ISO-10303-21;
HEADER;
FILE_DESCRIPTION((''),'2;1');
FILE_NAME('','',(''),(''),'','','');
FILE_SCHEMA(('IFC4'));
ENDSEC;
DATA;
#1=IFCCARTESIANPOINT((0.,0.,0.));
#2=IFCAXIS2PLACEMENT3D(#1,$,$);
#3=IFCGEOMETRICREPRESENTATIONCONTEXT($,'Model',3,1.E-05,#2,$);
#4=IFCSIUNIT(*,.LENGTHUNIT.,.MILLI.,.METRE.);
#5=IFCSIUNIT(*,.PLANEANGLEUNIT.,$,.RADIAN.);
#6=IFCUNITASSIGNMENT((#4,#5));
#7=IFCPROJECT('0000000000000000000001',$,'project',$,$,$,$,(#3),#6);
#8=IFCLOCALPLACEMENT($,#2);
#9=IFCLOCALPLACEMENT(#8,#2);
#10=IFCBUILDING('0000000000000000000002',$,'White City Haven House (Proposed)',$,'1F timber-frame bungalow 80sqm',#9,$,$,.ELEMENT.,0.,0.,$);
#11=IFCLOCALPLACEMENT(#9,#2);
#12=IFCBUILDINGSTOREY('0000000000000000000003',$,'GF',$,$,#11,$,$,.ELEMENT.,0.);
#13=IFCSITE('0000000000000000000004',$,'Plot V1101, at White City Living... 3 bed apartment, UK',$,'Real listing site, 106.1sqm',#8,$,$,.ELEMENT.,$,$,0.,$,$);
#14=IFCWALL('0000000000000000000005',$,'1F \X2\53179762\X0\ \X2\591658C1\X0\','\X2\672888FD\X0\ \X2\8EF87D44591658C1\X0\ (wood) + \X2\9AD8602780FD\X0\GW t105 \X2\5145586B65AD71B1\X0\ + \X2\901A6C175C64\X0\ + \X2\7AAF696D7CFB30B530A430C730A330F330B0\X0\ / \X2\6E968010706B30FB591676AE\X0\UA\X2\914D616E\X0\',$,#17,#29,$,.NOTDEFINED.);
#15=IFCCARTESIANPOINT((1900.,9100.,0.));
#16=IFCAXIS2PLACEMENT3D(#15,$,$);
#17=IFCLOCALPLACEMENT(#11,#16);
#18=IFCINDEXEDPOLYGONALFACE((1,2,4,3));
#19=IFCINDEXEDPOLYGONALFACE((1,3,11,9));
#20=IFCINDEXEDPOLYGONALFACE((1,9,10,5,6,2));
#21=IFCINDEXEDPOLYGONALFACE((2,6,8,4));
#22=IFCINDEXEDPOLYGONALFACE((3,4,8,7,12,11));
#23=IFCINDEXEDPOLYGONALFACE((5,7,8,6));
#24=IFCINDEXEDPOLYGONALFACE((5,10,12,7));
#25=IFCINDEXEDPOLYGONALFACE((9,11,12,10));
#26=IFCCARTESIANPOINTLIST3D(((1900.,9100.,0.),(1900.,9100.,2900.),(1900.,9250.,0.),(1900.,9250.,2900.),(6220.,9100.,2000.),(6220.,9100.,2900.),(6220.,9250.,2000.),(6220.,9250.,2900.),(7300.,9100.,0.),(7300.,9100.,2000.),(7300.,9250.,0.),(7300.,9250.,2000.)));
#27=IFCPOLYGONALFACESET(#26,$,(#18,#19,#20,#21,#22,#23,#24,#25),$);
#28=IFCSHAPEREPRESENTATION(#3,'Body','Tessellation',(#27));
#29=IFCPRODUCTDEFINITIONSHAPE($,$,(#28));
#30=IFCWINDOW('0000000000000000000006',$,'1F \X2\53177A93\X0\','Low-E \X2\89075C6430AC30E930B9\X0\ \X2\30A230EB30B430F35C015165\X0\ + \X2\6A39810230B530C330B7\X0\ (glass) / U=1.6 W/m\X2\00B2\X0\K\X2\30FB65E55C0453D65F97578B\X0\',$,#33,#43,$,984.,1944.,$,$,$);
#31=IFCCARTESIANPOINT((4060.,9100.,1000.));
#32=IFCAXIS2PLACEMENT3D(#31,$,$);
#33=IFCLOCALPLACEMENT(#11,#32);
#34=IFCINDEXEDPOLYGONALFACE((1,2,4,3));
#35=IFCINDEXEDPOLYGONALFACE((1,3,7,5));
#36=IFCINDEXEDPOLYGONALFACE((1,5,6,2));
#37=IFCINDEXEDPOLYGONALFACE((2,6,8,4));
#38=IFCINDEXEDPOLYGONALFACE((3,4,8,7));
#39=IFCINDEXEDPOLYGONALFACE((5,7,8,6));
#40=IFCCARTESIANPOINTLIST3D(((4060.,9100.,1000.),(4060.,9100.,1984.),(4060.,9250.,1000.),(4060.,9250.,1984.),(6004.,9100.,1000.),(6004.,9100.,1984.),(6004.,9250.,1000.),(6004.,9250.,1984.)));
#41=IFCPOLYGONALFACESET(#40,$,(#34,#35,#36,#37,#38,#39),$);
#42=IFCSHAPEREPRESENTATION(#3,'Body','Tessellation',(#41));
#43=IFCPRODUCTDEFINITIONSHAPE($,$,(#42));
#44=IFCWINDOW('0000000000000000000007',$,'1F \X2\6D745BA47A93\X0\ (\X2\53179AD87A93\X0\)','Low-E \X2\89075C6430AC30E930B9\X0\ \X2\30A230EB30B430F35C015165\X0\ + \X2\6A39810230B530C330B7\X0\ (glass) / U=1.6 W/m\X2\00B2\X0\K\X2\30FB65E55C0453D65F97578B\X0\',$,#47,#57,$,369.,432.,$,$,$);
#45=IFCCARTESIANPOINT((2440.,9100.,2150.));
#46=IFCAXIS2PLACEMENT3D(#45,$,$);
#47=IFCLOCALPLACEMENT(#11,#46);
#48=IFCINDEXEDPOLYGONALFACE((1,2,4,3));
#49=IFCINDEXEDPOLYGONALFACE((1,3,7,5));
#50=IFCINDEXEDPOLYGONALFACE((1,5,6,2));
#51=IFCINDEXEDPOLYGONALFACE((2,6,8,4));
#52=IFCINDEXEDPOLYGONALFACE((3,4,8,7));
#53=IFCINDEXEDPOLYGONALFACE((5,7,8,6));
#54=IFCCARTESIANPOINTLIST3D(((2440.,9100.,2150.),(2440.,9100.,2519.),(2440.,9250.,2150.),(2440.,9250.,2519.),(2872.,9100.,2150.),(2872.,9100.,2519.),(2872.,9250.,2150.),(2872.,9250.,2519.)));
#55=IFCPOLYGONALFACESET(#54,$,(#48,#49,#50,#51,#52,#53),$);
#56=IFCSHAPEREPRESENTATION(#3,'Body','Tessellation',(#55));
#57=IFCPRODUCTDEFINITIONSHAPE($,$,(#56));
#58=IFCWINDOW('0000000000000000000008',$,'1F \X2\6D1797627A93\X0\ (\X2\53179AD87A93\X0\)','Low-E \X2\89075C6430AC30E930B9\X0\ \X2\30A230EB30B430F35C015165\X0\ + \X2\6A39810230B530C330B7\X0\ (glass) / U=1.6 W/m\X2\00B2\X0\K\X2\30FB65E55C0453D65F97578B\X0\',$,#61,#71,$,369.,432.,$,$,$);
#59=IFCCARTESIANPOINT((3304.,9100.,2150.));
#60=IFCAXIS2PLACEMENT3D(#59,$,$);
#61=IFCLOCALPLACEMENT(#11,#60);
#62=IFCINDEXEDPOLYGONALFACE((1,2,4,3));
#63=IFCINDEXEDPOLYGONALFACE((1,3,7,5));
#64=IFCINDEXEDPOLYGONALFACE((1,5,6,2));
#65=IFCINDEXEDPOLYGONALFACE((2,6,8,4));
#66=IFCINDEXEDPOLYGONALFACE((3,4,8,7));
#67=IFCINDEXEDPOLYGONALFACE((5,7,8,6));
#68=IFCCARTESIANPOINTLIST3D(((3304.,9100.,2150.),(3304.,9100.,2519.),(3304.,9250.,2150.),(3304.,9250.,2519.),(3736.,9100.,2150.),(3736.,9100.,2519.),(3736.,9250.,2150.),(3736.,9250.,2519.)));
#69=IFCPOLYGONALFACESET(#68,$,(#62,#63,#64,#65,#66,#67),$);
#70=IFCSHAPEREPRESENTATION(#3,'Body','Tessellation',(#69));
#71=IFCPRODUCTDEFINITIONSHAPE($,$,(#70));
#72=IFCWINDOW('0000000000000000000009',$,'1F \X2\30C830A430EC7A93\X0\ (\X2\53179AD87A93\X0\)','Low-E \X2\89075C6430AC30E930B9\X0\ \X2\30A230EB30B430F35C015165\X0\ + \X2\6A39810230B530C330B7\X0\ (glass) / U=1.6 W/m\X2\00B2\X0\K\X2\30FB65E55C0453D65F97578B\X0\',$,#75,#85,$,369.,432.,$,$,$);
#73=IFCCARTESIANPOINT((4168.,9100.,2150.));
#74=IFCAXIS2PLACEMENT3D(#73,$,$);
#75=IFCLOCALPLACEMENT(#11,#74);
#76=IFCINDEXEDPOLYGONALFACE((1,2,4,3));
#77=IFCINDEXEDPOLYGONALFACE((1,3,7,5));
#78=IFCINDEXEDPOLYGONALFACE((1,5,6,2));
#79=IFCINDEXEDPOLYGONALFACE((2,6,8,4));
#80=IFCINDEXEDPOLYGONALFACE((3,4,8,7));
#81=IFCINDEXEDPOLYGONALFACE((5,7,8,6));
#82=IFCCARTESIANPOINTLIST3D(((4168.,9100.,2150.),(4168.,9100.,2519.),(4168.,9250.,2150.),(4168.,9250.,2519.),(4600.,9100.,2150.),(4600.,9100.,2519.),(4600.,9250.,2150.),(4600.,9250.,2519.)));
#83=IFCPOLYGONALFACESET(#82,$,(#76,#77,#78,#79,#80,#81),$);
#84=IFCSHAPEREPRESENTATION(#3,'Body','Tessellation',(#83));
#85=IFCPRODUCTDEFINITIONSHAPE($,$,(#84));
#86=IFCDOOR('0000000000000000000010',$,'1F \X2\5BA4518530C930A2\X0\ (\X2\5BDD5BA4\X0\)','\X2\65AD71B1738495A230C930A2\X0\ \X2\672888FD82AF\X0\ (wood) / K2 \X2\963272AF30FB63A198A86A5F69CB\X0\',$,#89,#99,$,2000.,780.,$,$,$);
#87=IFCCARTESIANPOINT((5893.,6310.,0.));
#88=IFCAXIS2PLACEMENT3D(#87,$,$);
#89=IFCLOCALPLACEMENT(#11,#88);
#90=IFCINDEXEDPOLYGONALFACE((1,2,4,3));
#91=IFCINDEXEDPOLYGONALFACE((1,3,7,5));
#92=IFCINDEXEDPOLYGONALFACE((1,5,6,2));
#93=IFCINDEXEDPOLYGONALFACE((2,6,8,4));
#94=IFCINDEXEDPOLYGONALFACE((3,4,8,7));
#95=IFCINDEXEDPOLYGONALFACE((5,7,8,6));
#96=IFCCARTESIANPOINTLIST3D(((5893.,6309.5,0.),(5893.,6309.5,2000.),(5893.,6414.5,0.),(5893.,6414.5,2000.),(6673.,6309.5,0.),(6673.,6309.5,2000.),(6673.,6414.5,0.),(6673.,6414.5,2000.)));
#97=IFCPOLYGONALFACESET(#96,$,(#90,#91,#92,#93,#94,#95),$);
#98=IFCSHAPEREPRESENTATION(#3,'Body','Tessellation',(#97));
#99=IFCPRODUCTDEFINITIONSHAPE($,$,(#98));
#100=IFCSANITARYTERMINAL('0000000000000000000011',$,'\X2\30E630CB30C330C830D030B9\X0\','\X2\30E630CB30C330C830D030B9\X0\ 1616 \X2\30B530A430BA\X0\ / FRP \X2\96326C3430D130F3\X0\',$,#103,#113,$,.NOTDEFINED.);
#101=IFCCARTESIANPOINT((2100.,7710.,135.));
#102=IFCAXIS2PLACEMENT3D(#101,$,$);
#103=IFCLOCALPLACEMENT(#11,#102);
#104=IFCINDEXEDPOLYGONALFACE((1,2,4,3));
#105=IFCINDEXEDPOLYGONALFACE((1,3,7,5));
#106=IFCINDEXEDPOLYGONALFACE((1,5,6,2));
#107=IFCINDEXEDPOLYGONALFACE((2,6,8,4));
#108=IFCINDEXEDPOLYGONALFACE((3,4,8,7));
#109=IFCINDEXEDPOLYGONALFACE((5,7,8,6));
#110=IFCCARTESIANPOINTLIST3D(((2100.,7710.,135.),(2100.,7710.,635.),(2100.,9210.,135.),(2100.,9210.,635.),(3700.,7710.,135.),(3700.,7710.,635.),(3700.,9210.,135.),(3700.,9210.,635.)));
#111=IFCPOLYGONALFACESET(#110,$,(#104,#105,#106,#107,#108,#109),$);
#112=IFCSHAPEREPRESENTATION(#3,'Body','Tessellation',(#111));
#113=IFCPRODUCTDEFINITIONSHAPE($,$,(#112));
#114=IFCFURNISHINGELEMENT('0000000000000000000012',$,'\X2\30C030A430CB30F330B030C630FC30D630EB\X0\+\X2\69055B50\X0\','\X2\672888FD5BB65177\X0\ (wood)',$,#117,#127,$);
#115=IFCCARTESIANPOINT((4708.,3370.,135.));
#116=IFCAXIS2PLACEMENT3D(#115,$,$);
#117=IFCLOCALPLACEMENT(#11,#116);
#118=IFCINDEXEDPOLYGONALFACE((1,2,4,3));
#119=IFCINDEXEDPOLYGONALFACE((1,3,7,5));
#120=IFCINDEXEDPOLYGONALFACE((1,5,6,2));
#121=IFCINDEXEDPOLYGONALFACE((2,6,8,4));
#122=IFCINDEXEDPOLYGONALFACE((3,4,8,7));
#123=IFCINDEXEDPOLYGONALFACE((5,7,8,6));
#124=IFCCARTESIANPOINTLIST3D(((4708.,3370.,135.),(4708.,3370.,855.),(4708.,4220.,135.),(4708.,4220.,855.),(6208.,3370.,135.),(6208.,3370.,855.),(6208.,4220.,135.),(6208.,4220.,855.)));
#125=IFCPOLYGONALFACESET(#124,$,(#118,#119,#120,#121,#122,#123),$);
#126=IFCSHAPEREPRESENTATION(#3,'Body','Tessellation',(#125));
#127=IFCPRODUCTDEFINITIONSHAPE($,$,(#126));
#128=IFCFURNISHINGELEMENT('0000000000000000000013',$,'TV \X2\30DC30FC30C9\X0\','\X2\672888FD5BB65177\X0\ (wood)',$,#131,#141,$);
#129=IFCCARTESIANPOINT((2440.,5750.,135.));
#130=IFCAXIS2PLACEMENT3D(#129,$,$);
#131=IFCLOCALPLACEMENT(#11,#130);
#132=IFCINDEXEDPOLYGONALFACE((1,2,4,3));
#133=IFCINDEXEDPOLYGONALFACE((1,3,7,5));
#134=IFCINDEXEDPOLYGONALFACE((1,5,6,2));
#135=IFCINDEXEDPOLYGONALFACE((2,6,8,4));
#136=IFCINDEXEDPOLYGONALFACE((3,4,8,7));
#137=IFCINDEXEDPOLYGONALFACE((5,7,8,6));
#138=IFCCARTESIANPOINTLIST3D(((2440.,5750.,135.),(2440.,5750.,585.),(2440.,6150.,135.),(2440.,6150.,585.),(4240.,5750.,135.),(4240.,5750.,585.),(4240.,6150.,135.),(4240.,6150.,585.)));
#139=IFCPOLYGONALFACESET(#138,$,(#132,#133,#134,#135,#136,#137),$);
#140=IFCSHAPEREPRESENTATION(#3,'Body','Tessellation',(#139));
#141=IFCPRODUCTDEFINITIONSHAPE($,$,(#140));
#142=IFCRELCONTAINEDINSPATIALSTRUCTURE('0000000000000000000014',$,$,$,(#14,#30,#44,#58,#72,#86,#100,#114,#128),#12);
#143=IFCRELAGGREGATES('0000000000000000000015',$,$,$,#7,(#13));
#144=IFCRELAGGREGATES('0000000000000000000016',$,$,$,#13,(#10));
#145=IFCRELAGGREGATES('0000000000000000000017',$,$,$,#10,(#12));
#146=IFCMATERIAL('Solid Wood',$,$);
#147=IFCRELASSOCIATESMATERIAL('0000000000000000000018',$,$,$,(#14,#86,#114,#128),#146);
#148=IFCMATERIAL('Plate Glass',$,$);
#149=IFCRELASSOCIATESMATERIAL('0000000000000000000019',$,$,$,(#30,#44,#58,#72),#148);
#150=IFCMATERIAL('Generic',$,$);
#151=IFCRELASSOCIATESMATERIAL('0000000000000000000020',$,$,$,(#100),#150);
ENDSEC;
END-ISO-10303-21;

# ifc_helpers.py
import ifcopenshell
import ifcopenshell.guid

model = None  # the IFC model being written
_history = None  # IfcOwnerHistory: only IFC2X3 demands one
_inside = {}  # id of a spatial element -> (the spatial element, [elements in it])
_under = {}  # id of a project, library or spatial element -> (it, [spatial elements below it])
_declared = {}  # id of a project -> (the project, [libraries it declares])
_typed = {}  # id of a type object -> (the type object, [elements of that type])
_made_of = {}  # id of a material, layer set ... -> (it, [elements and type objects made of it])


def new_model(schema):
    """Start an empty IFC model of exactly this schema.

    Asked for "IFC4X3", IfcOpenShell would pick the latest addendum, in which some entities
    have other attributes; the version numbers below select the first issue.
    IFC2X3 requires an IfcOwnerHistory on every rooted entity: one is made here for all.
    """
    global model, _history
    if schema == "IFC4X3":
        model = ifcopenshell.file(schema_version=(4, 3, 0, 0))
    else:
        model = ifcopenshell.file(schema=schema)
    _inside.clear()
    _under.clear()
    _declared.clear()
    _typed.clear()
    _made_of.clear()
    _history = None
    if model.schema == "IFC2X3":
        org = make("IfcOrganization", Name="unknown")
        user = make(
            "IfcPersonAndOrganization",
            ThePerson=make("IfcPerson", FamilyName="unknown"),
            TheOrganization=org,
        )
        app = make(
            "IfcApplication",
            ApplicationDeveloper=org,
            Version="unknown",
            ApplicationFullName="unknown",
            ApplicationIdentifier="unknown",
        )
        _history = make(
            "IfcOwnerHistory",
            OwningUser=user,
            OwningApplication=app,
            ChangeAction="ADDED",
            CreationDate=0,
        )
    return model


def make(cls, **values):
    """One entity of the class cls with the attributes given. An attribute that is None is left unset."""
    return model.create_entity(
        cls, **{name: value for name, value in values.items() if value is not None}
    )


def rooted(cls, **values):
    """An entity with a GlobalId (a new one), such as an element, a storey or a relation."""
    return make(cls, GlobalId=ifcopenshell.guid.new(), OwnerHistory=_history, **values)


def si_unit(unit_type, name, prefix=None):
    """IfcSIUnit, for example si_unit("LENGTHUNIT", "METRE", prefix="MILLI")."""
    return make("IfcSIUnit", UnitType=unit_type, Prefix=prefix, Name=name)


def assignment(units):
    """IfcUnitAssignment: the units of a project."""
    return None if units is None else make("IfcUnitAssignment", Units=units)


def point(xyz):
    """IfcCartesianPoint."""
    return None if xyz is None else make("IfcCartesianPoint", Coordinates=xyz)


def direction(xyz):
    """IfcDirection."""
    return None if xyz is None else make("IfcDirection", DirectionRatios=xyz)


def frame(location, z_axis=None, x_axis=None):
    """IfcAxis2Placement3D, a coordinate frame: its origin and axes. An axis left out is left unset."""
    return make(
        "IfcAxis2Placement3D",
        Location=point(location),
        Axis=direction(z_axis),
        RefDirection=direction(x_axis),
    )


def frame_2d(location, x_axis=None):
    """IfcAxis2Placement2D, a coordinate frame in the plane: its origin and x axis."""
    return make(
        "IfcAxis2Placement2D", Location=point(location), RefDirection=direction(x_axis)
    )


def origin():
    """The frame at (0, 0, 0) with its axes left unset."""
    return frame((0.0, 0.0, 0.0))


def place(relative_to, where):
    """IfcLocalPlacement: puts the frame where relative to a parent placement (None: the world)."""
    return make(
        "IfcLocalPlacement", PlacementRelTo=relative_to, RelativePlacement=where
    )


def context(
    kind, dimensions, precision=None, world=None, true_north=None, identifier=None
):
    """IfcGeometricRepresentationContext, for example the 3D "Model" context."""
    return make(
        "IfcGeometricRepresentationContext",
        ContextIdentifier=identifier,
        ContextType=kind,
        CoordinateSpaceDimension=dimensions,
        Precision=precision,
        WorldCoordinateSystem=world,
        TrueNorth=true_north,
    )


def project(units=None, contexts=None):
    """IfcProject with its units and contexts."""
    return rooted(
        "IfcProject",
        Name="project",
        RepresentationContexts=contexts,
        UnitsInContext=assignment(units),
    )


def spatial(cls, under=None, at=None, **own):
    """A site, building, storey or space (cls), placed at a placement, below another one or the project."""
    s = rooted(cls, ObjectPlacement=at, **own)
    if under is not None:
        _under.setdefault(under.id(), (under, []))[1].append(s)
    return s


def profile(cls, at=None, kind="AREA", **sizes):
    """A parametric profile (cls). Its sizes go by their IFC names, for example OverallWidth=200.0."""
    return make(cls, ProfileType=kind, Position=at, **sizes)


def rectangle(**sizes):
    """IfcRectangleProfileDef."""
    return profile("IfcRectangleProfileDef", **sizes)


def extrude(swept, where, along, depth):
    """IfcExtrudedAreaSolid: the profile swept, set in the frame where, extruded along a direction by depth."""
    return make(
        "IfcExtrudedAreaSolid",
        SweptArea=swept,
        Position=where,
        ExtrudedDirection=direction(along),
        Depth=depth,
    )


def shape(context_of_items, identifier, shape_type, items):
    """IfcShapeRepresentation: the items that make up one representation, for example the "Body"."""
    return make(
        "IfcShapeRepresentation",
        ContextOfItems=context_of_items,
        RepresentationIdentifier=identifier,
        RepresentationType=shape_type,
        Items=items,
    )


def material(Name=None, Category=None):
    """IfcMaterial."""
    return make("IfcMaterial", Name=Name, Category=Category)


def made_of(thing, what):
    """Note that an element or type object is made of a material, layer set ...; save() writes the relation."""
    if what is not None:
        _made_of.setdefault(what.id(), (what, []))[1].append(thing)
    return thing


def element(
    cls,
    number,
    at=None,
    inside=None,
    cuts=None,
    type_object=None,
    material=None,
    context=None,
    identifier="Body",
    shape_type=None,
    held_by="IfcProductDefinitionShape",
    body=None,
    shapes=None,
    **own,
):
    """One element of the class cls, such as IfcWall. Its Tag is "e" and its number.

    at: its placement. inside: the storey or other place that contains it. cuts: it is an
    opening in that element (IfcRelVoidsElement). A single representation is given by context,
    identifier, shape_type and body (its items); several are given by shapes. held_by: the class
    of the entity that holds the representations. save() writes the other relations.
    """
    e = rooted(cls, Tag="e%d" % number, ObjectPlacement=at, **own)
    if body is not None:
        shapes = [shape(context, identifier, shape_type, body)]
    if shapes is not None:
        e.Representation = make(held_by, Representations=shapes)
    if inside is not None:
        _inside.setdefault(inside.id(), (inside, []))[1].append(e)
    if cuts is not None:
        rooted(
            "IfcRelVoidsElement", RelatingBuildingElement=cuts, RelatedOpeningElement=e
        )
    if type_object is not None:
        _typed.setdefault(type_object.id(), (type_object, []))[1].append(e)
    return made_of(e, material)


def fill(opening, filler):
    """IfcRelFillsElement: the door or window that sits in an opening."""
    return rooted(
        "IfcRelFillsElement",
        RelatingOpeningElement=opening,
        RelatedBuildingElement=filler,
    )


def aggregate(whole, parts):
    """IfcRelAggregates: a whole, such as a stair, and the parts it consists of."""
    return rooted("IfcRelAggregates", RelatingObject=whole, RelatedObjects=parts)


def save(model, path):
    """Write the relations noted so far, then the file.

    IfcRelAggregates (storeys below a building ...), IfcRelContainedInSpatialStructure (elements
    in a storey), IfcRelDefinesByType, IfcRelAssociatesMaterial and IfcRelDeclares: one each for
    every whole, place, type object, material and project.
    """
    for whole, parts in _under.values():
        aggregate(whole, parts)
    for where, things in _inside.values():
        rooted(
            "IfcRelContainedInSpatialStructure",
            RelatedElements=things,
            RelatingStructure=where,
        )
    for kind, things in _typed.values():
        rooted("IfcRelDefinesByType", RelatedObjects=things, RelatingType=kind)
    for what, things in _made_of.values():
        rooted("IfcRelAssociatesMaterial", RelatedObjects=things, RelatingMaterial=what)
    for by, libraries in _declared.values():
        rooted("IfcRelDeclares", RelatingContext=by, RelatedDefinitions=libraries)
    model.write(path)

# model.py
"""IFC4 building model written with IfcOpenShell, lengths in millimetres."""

from ifc_helpers import new_model, si_unit, frame, frame_2d, origin, place, context, project, spatial, rectangle, extrude, material, element, fill, save


model = new_model("IFC4")

# Units and contexts
model_context = context("Model", 3, precision=1e-05, world=origin())
ifc_project = project(units=[si_unit("LENGTHUNIT", "METRE", prefix="MILLI"), si_unit("PLANEANGLEUNIT", "RADIAN")], contexts=[model_context])

# Site, building, storey
site_placement = place(None, origin())
site = spatial("IfcSite", under=ifc_project, at=site_placement, Name="Plot V1101, at White City Living... 3 bed apartment, UK", ObjectType="Real listing site, 106.1sqm", CompositionType="ELEMENT", RefElevation=0.0)
building_placement = place(site_placement, origin())
building = spatial("IfcBuilding", under=site, at=building_placement, Name="White City Haven House (Proposed)", ObjectType="1F timber-frame bungalow 80sqm", CompositionType="ELEMENT", ElevationOfRefHeight=0.0, ElevationOfTerrain=0.0)
storey_placement = place(building_placement, origin())
storey = spatial("IfcBuildingStorey", under=building, at=storey_placement, Name="GF", CompositionType="ELEMENT", Elevation=0.0)

# Wall, openings, windows
ifc_material_1 = material(Name="Solid Wood")
wall_1_placement = place(storey_placement, frame((1900.0, 9100.0, 0.0)))
wall_1 = element("IfcWall", 1, at=wall_1_placement, inside=storey, material=ifc_material_1, Name="1F 北面 外壁", Description="木製 軸組外壁 (wood) + 高性能GW t105 充填断熱 + 通気層 + 窯業系サイディング / 準耐火・外皮UA配慮", PredefinedType="NOTDEFINED", context=model_context, shape_type="SweptSolid", body=[
    extrude(rectangle(XDim=5400.0, YDim=150.0, at=frame_2d((2700.0, 75.0))), frame((1900.0, 9100.0, 0.0)), (0.0, 0.0, 1.0), 2900.0),
])
opening_1_placement = place(storey_placement, frame((4060.0, 9100.0, 1000.0)))
opening_1 = element("IfcOpeningElement", 2, at=opening_1_placement, cuts=wall_1, PredefinedType="NOTDEFINED", context=model_context, shape_type="SweptSolid", body=[
    extrude(rectangle(XDim=1944.0, YDim=150.0, at=frame_2d((972.0, 75.0))), frame((4060.0, 9100.0, 1000.0)), (0.0, 0.0, 1.0), 984.0),
])
opening_2_placement = place(storey_placement, frame((2440.0, 9100.0, 2150.0)))
opening_2 = element("IfcOpeningElement", 3, at=opening_2_placement, cuts=wall_1, PredefinedType="NOTDEFINED", context=model_context, shape_type="SweptSolid", body=[
    extrude(rectangle(XDim=432.0, YDim=150.0, at=frame_2d((216.0, 75.0))), frame((2440.0, 9100.0, 2150.0)), (0.0, 0.0, 1.0), 369.0),
])
opening_3_placement = place(storey_placement, frame((3304.0, 9100.0, 2150.0)))
opening_3 = element("IfcOpeningElement", 4, at=opening_3_placement, cuts=wall_1, PredefinedType="NOTDEFINED", context=model_context, shape_type="SweptSolid", body=[
    extrude(rectangle(XDim=432.0, YDim=150.0, at=frame_2d((216.0, 75.0))), frame((3304.0, 9100.0, 2150.0)), (0.0, 0.0, 1.0), 369.0),
])
opening_4_placement = place(storey_placement, frame((4168.0, 9100.0, 2150.0)))
opening_4 = element("IfcOpeningElement", 5, at=opening_4_placement, cuts=wall_1, PredefinedType="NOTDEFINED", context=model_context, shape_type="SweptSolid", body=[
    extrude(rectangle(XDim=432.0, YDim=150.0, at=frame_2d((216.0, 75.0))), frame((4168.0, 9100.0, 2150.0)), (0.0, 0.0, 1.0), 369.0),
])
ifc_material_2 = material(Name="Plate Glass")
window_1_placement = place(storey_placement, frame((4060.0, 9100.0, 1000.0)))
window_1 = element("IfcWindow", 6, at=window_1_placement, inside=storey, material=ifc_material_2, Name="1F 北窓", Description="Low-E 複層ガラス アルゴン封入 + 樹脂サッシ (glass) / U=1.6 W/m²K・日射取得型", OverallHeight=984.0, OverallWidth=1944.0, context=model_context, shape_type="SweptSolid", body=[
    extrude(rectangle(XDim=1944.0, YDim=150.0, at=frame_2d((972.0, 75.0))), frame((4060.0, 9100.0, 1000.0)), (0.0, 0.0, 1.0), 984.0),
])
fill(opening_1, window_1)
window_2_placement = place(storey_placement, frame((2440.0, 9100.0, 2150.0)))
window_2 = element("IfcWindow", 7, at=window_2_placement, inside=storey, material=ifc_material_2, Name="1F 浴室窓 (北高窓)", Description="Low-E 複層ガラス アルゴン封入 + 樹脂サッシ (glass) / U=1.6 W/m²K・日射取得型", OverallHeight=369.0, OverallWidth=432.0, context=model_context, shape_type="SweptSolid", body=[
    extrude(rectangle(XDim=432.0, YDim=150.0, at=frame_2d((216.0, 75.0))), frame((2440.0, 9100.0, 2150.0)), (0.0, 0.0, 1.0), 369.0),
])
fill(opening_2, window_2)
window_3_placement = place(storey_placement, frame((3304.0, 9100.0, 2150.0)))
window_3 = element("IfcWindow", 8, at=window_3_placement, inside=storey, material=ifc_material_2, Name="1F 洗面窓 (北高窓)", Description="Low-E 複層ガラス アルゴン封入 + 樹脂サッシ (glass) / U=1.6 W/m²K・日射取得型", OverallHeight=369.0, OverallWidth=432.0, context=model_context, shape_type="SweptSolid", body=[
    extrude(rectangle(XDim=432.0, YDim=150.0, at=frame_2d((216.0, 75.0))), frame((3304.0, 9100.0, 2150.0)), (0.0, 0.0, 1.0), 369.0),
])
fill(opening_3, window_3)
window_4_placement = place(storey_placement, frame((4168.0, 9100.0, 2150.0)))
window_4 = element("IfcWindow", 9, at=window_4_placement, inside=storey, material=ifc_material_2, Name="1F トイレ窓 (北高窓)", Description="Low-E 複層ガラス アルゴン封入 + 樹脂サッシ (glass) / U=1.6 W/m²K・日射取得型", OverallHeight=369.0, OverallWidth=432.0, context=model_context, shape_type="SweptSolid", body=[
    extrude(rectangle(XDim=432.0, YDim=150.0, at=frame_2d((216.0, 75.0))), frame((4168.0, 9100.0, 2150.0)), (0.0, 0.0, 1.0), 369.0),
])
fill(opening_4, window_4)

# Door
door_1_placement = place(storey_placement, frame((5893.0, 6310.0, 0.0)))
element("IfcDoor", 10, at=door_1_placement, inside=storey, material=ifc_material_1, Name="1F 室内ドア (寝室)", Description="断熱玄関ドア 木製芯 (wood) / K2 防犯・採風機構", OverallHeight=2000.0, OverallWidth=780.0, context=model_context, shape_type="SweptSolid", body=[
    extrude(rectangle(XDim=780.0, YDim=105.0, at=frame_2d((390.0, 52.0))), frame((5893.0, 6310.0, 0.0)), (0.0, 0.0, 1.0), 2000.0),
])

# Shared definitions
ifc_material_3 = material(Name="Generic")

# Sanitary terminal
sanitary_terminal_placement = place(storey_placement, frame((2100.0, 7710.0, 135.0)))
element("IfcSanitaryTerminal", 11, at=sanitary_terminal_placement, inside=storey, material=ifc_material_3, Name="ユニットバス", Description="ユニットバス 1616 サイズ / FRP 防水パン", PredefinedType="NOTDEFINED", context=model_context, shape_type="SweptSolid", body=[
    extrude(rectangle(XDim=1600.0, YDim=1500.0, at=frame_2d((800.0, 750.0))), frame((2100.0, 7710.0, 135.0)), (0.0, 0.0, 1.0), 500.0),
])

# Furnishing elements
furnishing_1_placement = place(storey_placement, frame((4708.0, 3370.0, 135.0)))
element("IfcFurnishingElement", 12, at=furnishing_1_placement, inside=storey, material=ifc_material_1, Name="ダイニングテーブル+椅子", Description="木製家具 (wood)", context=model_context, shape_type="SweptSolid", body=[
    extrude(rectangle(XDim=1500.0, YDim=850.0, at=frame_2d((750.0, 425.0))), frame((4708.0, 3370.0, 135.0)), (0.0, 0.0, 1.0), 720.0),
])
furnishing_2_placement = place(storey_placement, frame((2440.0, 5750.0, 135.0)))
element("IfcFurnishingElement", 13, at=furnishing_2_placement, inside=storey, material=ifc_material_1, Name="TV ボード", Description="木製家具 (wood)", context=model_context, shape_type="SweptSolid", body=[
    extrude(rectangle(XDim=1800.0, YDim=400.0, at=frame_2d((900.0, 200.0))), frame((2440.0, 5750.0, 135.0)), (0.0, 0.0, 1.0), 450.0),
])

save(model, "model.ifc")
